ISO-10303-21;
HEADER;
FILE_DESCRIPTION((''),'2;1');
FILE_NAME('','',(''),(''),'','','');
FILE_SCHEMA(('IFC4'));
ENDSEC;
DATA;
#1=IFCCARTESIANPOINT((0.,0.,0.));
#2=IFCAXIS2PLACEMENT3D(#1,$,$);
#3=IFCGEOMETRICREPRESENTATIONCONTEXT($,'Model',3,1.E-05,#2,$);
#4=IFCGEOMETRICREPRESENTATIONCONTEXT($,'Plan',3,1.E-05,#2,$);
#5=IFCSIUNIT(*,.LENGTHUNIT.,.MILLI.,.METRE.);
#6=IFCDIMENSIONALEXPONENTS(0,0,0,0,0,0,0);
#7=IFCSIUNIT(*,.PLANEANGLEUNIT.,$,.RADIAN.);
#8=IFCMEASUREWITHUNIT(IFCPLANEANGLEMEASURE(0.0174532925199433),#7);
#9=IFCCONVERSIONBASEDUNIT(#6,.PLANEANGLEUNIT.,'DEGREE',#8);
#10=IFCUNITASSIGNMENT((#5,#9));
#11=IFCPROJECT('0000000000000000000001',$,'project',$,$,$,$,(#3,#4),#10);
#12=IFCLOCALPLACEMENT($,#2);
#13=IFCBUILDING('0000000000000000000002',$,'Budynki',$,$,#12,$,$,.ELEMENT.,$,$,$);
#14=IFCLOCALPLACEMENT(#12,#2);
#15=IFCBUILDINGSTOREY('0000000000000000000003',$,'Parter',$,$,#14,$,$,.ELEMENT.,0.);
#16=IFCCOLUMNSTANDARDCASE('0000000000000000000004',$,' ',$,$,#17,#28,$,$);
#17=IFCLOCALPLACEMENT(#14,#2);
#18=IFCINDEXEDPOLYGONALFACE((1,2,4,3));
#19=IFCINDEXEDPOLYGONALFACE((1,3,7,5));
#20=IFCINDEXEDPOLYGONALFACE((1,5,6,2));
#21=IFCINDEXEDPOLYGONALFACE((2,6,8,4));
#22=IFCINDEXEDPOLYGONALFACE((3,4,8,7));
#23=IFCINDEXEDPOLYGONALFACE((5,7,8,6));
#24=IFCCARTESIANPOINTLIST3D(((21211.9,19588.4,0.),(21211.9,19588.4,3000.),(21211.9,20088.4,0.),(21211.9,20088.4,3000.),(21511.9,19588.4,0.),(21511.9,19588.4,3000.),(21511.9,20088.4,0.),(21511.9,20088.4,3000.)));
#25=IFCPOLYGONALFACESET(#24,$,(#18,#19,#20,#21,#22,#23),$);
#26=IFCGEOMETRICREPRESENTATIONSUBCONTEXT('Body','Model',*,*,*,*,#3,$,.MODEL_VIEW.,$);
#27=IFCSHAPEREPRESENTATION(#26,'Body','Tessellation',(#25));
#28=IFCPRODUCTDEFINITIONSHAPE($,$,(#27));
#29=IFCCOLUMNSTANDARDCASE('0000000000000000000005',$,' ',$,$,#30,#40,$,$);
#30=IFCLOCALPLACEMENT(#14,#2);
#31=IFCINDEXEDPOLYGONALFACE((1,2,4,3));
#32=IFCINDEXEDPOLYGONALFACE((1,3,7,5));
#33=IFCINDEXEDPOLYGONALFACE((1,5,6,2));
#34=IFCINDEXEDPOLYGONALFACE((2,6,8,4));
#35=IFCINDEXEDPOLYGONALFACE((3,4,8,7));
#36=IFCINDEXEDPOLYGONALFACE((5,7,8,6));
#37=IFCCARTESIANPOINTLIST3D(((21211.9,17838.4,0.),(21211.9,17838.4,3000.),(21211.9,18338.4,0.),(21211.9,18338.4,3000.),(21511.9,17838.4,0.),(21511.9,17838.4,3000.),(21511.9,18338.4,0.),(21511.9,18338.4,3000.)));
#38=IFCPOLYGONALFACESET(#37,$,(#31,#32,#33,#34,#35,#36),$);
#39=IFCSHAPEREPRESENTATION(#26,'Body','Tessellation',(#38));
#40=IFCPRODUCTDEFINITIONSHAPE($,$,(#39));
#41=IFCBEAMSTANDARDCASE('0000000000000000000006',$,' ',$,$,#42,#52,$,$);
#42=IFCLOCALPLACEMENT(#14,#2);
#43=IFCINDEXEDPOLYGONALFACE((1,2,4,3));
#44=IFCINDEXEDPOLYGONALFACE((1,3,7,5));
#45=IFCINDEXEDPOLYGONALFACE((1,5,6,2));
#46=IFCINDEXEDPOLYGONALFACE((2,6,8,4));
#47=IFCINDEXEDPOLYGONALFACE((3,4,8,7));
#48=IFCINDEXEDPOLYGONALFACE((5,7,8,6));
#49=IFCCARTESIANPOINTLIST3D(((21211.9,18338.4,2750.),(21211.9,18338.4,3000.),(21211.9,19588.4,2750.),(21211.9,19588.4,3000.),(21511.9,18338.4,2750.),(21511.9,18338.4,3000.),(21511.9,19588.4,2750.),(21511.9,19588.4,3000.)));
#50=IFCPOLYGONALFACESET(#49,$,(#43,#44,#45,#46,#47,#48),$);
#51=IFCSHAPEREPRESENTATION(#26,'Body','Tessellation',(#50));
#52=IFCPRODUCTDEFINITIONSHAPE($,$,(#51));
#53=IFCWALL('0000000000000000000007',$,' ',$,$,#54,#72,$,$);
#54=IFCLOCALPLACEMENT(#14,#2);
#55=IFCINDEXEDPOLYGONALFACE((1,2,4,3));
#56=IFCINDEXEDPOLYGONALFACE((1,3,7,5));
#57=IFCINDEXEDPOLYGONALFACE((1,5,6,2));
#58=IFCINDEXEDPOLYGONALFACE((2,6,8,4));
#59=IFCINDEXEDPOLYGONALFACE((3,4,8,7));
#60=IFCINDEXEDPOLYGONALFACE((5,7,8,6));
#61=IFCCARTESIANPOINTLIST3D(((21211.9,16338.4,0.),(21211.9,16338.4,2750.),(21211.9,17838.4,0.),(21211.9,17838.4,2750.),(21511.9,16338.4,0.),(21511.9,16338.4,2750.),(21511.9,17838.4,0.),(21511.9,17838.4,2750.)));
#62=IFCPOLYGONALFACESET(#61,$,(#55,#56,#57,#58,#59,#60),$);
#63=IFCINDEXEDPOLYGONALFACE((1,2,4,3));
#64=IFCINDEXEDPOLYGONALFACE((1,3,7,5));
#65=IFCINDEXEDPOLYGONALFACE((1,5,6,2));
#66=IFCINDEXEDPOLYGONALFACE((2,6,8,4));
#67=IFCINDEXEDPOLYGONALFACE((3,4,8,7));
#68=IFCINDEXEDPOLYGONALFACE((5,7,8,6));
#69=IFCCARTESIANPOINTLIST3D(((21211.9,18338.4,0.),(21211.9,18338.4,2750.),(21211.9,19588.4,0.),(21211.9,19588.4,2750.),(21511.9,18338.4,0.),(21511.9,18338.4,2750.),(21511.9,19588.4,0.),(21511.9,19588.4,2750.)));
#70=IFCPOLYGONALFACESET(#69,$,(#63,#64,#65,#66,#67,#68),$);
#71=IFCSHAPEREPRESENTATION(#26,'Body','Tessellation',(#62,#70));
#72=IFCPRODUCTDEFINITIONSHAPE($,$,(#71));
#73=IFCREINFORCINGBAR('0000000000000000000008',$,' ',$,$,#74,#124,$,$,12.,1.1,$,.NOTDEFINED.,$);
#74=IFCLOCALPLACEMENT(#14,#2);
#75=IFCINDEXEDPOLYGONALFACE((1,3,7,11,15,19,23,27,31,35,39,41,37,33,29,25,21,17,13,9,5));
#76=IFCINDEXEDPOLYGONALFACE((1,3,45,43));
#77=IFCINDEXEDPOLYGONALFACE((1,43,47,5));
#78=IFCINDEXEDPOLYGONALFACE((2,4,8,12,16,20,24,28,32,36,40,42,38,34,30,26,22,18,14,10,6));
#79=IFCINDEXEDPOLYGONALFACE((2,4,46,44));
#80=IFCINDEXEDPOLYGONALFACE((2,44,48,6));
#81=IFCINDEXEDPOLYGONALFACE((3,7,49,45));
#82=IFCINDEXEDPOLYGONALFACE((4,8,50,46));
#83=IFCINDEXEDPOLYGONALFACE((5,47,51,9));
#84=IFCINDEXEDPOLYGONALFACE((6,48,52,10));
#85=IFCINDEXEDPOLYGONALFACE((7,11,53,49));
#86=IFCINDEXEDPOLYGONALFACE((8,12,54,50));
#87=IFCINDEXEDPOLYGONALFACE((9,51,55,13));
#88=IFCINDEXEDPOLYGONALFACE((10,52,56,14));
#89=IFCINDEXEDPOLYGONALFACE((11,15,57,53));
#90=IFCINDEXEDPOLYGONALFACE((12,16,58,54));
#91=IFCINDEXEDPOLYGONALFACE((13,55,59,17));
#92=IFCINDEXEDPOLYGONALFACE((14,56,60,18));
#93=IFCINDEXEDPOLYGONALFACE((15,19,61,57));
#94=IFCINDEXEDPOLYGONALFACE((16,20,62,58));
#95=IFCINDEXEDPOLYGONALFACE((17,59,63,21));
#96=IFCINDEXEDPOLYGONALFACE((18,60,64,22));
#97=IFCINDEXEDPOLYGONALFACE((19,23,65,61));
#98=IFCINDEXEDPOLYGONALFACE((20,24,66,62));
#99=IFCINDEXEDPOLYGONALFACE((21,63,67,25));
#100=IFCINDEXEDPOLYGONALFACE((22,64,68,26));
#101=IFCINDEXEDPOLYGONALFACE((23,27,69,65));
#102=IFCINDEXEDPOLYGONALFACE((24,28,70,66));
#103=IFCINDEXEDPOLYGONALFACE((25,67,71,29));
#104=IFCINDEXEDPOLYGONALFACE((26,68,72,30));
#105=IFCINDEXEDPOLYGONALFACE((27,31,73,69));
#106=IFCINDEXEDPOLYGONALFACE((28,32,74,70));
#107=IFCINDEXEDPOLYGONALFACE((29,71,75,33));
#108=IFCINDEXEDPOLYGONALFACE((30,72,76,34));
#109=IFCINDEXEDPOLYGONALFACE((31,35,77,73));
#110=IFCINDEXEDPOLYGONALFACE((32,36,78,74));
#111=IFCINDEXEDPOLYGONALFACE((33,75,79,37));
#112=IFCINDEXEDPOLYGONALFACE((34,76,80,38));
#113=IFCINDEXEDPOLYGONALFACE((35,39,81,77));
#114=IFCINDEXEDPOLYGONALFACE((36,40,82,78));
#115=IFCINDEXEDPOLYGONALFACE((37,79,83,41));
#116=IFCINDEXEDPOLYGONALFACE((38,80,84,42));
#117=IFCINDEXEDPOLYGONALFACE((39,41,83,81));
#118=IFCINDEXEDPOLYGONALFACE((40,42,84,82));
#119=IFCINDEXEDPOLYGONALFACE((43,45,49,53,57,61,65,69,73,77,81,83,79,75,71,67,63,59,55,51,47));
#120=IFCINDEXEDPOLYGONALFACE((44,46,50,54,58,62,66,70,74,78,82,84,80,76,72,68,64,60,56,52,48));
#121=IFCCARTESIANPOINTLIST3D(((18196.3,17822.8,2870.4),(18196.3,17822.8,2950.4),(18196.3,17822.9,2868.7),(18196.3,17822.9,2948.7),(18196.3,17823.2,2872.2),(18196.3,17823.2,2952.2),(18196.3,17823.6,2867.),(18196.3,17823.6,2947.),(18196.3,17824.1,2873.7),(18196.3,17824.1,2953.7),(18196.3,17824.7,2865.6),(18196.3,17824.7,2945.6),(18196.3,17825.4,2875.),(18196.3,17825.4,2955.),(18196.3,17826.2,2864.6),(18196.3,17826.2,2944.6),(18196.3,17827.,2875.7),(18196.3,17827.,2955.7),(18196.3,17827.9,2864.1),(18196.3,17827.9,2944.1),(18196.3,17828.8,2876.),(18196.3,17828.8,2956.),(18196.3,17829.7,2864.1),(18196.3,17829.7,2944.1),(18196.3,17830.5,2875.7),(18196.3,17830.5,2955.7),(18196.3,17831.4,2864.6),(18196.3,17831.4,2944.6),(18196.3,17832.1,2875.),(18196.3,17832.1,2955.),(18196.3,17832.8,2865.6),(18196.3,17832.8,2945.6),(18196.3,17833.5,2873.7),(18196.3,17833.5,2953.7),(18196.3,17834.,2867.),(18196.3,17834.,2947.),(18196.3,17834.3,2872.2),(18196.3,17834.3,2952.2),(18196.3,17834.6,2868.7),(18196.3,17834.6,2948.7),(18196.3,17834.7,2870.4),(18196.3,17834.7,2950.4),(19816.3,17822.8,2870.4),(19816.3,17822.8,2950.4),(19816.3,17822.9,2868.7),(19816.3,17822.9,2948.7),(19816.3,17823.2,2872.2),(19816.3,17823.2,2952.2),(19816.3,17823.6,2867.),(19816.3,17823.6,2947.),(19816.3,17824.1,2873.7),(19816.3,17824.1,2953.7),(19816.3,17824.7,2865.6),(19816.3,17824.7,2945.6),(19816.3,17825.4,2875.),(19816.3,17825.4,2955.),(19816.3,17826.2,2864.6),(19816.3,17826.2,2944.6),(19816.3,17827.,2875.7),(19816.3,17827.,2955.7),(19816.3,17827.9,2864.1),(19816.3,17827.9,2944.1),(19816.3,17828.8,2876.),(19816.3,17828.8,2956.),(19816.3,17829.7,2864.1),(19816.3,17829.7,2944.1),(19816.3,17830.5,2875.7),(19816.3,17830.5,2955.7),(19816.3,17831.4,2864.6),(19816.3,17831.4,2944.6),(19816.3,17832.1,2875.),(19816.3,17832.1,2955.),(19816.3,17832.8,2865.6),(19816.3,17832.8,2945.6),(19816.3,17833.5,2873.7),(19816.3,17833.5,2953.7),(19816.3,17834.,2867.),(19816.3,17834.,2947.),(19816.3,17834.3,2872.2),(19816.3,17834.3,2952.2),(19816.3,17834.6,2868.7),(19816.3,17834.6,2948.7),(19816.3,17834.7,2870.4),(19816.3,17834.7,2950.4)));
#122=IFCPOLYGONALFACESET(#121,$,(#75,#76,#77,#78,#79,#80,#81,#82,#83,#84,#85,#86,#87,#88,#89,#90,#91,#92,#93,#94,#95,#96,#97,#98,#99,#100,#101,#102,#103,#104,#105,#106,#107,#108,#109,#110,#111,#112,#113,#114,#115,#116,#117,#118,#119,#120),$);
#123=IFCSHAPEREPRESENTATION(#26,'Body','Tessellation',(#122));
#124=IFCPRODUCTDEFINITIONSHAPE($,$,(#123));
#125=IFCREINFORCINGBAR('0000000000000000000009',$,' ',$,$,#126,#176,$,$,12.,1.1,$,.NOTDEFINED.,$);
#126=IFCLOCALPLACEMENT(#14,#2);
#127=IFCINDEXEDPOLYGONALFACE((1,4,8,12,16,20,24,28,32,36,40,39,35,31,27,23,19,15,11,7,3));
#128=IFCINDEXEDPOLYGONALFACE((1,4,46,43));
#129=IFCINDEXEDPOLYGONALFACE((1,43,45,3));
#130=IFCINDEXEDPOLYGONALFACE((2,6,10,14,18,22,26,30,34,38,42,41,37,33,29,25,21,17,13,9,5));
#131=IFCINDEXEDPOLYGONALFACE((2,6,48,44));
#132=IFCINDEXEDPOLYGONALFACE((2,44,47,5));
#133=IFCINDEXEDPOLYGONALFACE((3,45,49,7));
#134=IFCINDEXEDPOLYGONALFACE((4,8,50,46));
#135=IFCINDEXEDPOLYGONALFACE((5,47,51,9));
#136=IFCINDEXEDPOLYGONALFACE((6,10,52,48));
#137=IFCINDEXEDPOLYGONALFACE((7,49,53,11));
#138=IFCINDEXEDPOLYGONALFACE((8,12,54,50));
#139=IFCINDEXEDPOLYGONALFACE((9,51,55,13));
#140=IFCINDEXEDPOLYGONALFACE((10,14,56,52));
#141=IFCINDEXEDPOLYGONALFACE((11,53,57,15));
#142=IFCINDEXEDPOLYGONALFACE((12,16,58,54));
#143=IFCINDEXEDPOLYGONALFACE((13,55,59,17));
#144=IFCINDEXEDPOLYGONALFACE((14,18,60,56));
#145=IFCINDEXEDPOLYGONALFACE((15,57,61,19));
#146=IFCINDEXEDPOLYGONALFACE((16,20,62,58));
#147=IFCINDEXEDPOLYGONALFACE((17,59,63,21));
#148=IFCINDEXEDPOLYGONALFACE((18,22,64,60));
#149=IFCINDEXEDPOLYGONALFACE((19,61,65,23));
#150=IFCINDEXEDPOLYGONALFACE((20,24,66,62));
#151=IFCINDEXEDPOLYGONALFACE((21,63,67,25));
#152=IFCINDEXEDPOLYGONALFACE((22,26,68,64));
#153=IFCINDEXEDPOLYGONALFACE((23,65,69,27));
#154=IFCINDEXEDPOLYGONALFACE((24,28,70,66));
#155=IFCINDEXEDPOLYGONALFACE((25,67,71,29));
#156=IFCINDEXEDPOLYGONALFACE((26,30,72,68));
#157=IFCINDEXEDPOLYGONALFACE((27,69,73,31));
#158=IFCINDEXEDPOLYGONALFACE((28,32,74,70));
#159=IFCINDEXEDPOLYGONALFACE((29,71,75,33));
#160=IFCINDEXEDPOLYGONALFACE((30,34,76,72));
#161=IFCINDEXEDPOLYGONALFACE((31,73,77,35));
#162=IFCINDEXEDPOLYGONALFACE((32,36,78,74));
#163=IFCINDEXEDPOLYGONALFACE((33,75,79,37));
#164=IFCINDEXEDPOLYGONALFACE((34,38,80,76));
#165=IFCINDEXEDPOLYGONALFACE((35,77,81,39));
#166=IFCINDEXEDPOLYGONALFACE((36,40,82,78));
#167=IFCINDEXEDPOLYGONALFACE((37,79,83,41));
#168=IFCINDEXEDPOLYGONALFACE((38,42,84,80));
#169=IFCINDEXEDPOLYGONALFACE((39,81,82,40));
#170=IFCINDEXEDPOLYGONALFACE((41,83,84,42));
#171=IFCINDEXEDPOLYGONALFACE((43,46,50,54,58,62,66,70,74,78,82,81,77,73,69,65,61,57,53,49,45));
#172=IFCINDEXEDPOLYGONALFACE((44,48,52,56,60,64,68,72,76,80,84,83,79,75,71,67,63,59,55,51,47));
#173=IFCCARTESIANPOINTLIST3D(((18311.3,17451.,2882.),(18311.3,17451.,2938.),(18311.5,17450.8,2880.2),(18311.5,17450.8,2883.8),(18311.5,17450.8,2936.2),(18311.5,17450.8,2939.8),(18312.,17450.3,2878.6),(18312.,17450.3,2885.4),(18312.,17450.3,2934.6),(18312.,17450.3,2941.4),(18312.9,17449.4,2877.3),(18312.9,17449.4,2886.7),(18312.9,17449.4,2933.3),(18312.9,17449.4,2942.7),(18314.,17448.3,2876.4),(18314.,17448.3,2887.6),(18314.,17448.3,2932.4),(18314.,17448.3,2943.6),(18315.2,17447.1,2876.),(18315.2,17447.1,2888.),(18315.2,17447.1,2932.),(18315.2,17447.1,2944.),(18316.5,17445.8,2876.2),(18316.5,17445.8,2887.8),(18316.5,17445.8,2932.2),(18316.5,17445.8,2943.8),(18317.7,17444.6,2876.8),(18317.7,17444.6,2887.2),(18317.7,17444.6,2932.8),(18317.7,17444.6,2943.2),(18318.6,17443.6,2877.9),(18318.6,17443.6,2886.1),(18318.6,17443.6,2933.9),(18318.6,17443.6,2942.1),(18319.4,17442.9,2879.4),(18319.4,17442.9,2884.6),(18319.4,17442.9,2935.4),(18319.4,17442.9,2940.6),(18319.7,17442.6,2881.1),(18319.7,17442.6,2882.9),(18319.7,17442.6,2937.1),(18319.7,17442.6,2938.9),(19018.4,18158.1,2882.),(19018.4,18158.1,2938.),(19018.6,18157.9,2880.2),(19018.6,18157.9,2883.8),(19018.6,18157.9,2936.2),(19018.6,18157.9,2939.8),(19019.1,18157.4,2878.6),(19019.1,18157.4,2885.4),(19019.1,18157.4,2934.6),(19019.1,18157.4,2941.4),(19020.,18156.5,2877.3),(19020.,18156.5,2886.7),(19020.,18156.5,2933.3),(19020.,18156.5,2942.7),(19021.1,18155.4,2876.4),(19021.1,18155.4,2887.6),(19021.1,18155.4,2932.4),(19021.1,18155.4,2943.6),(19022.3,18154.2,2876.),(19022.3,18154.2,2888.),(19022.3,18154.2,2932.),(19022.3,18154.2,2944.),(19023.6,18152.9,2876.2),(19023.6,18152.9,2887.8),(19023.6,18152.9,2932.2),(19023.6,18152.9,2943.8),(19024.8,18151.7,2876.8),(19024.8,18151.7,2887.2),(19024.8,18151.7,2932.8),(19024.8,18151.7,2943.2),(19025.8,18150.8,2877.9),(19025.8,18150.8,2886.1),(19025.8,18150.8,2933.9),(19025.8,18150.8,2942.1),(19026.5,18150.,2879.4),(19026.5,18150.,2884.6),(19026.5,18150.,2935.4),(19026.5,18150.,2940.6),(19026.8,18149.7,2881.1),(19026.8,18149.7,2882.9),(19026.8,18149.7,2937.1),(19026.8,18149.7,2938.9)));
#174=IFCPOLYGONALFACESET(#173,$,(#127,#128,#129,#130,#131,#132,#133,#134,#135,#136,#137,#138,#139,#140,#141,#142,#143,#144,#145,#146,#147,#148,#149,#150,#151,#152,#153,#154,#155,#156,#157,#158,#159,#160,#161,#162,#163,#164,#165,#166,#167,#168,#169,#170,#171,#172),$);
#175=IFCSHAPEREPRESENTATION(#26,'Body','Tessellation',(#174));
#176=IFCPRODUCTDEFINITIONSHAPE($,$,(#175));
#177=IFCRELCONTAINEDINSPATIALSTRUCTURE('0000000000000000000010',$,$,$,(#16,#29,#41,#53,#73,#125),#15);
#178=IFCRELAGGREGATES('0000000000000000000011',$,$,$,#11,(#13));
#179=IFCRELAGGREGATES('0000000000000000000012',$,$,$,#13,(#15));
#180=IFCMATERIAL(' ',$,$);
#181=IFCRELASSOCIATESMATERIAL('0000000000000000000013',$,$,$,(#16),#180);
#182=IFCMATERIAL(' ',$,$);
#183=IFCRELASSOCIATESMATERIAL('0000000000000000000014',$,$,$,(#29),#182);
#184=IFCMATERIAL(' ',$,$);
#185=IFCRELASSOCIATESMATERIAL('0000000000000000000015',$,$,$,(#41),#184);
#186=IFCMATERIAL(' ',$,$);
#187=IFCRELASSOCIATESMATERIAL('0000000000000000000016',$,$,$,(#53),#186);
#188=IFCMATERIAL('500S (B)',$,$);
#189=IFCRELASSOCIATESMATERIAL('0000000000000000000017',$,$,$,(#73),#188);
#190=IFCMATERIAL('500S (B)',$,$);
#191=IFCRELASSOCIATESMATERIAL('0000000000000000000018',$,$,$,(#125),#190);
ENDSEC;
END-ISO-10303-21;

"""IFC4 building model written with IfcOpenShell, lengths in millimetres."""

from ifc_helpers import new_model, entity, si_unit, converted_unit, frame, frame_2d, origin, origin_with_axes, place, context, subcontext, project, spatial, rectangle, extrude, source, transform, mapped, material, material_profile, profile_set, profile_usage, element, save


model = new_model("IFC4")

# Units and contexts
model_context = context("Model", 3, precision=1e-05, world=origin())
plan_context = context("Plan", 3, precision=1e-05, world=origin())
body_context = subcontext(model_context, "Body", "Model", "MODEL_VIEW")
ifc_project = project(units=[si_unit("LENGTHUNIT", "METRE", prefix="MILLI"), converted_unit("PLANEANGLEUNIT", "DEGREE", entity("IfcPlaneAngleMeasure", 0.0174532925199433), si_unit("PLANEANGLEUNIT", "RADIAN"), dimensions=[0, 0, 0, 0, 0, 0, 0])], contexts=[model_context, plan_context])

# Building, storey
building_placement = place(None, origin())
building = spatial("IfcBuilding", under=ifc_project, at=building_placement, Name="Budynki", CompositionType="ELEMENT")
storey_placement = place(building_placement, origin())
storey = spatial("IfcBuildingStorey", under=building, at=storey_placement, Name="Parter", CompositionType="ELEMENT", Elevation=0.0)

# Columns
ifc_material_1 = material(Name=" ")
ifc_material_profile_1 = material_profile(ifc_material_1, rectangle(XDim=500.0, YDim=300.0, at=frame_2d((150.0, -250.0), x_axis=(0.0, -1.0))))
ifc_profile_set_1 = profile_set([ifc_material_profile_1])
ifc_profile_usage_1 = profile_usage(ifc_profile_set_1)
column_1_placement = place(storey_placement, frame((21211.9, 19588.4, 0.0)))
element("IfcColumnStandardCase", 1, at=column_1_placement, inside=storey, material=ifc_profile_usage_1, Name=" ", context=body_context, shape_type="SweptSolid", body=[
    extrude(rectangle(XDim=500.0, YDim=300.0, at=frame_2d((150.0, -250.0), x_axis=(0.0, -1.0))), frame((0.0, 500.0, 0.0), z_axis=(0.0, 0.0, 1.0), x_axis=(1.0, 0.0, 0.0)), (0.0, 0.0, 1.0), 3000.0),
])
ifc_material_2 = material(Name=" ")
ifc_material_profile_2 = material_profile(ifc_material_2, rectangle(XDim=500.0, YDim=300.0, at=frame_2d((-150.0, 250.0), x_axis=(0.0, 1.0))))
ifc_profile_set_2 = profile_set([ifc_material_profile_2])
ifc_profile_usage_2 = profile_usage(ifc_profile_set_2)
column_2_placement = place(storey_placement, frame((21211.9, 17838.4, 0.0)))
element("IfcColumnStandardCase", 2, at=column_2_placement, inside=storey, material=ifc_profile_usage_2, Name=" ", context=body_context, shape_type="SweptSolid", body=[
    extrude(rectangle(XDim=500.0, YDim=300.0, at=frame_2d((-150.0, 250.0), x_axis=(0.0, 1.0))), frame((300.0, 0.0, 0.0), z_axis=(0.0, 0.0, 1.0), x_axis=(1.0, 0.0, 0.0)), (0.0, 0.0, 1.0), 3000.0),
])

# Beam
ifc_material_3 = material(Name=" ")
ifc_material_profile_3 = material_profile(ifc_material_3, rectangle(XDim=300.0, YDim=250.0, at=frame_2d((125.0, -150.0), x_axis=(0.0, 1.0))))
ifc_profile_set_3 = profile_set([ifc_material_profile_3])
ifc_profile_usage_3 = profile_usage(ifc_profile_set_3)
beam_placement = place(storey_placement, frame((21211.9, 19588.4, 2750.0), z_axis=(0.0, 0.0, 1.0), x_axis=(0.0, -1.0, 0.0)))
element("IfcBeamStandardCase", 3, at=beam_placement, inside=storey, material=ifc_profile_usage_3, Name=" ", context=body_context, shape_type="SweptSolid", body=[
    extrude(rectangle(XDim=300.0, YDim=250.0, at=frame_2d((125.0, -150.0), x_axis=(0.0, 1.0))), frame((0.0, 0.0, 0.0), z_axis=(1.0, 0.0, 0.0), x_axis=(0.0, 0.0, 1.0)), (0.0, 0.0, 1.0), 1250.0),
])

# Wall
ifc_material_4 = material(Name=" ")
wall_placement = place(storey_placement, frame((21211.9, 20088.4, 0.0), z_axis=(0.0, 0.0, 1.0), x_axis=(0.0, -1.0, 0.0)))
element("IfcWall", 4, at=wall_placement, inside=storey, material=ifc_material_4, Name=" ", context=body_context, shape_type="SweptSolid", body=[
    extrude(rectangle(XDim=300.0, YDim=1500.0, at=frame_2d((-750.0, 150.0), x_axis=(0.0, 1.0))), frame((3750.0, 0.0, 0.0), z_axis=(0.0, 0.0, 1.0), x_axis=(1.0, 0.0, 0.0)), (0.0, 0.0, 1.0), 2750.0),
    extrude(rectangle(XDim=300.0, YDim=1250.0, at=frame_2d((-625.0, 150.0), x_axis=(0.0, 1.0))), frame((1750.0, 0.0, 0.0), z_axis=(0.0, 0.0, 1.0), x_axis=(1.0, 0.0, 0.0)), (0.0, 0.0, 1.0), 2750.0),
])

# Reinforcing bars
ifc_material_5 = material(Name="500S (B)")
shared_shape_1 = source(origin_with_axes(), body_context, "Body", "AdvancedSweptSolid", [
    entity("IfcSweptDiskSolid", entity("IfcPolyline", [entity("IfcCartesianPoint", [0.0, 0.0, 0.0]), entity("IfcCartesianPoint", [1620.0, 0.0, 0.0])]), 6.0, None, 0.0, 1.0),
])
reinforcing_bar_1_placement = place(storey_placement, frame((18196.3, 17828.8, 2870.0)))
element("IfcReinforcingBar", 5, at=reinforcing_bar_1_placement, inside=storey, material=ifc_material_5, Name=" ", CrossSectionArea=1.1, NominalDiameter=12.0, PredefinedType="NOTDEFINED", context=body_context, shape_type="MappedRepresentation", body=[
    mapped(shared_shape_1, transform((0.0, 0.0, 0.0), y_axis=(0.0, 1.0, 0.0), scale=1.0)),
    mapped(shared_shape_1, transform((0.0, 0.0, 80.0), y_axis=(0.0, 1.0, 0.0), scale=1.0)),
])
ifc_material_6 = material(Name="500S (B)")
shared_shape_2 = source(origin_with_axes(), body_context, "Body", "AdvancedSweptSolid", [
    entity("IfcSweptDiskSolid", entity("IfcPolyline", [entity("IfcCartesianPoint", [0.0, 0.0, 0.0]), entity("IfcCartesianPoint", [707.1, 707.1, 0.0])]), 6.0, None, 0.0, 1.0),
])
reinforcing_bar_2_placement = place(storey_placement, frame((18315.5, 17446.8, 2882.0)))
element("IfcReinforcingBar", 6, at=reinforcing_bar_2_placement, inside=storey, material=ifc_material_6, Name=" ", CrossSectionArea=1.1, NominalDiameter=12.0, PredefinedType="NOTDEFINED", context=body_context, shape_type="MappedRepresentation", body=[
    mapped(shared_shape_2, transform((0.0, 0.0, 0.0), y_axis=(0.0, 1.0, 0.0), scale=1.0)),
    mapped(shared_shape_2, transform((0.0, 0.0, 56.0), y_axis=(0.0, 1.0, 0.0), scale=1.0)),
])

save(model, "model.ifc")
